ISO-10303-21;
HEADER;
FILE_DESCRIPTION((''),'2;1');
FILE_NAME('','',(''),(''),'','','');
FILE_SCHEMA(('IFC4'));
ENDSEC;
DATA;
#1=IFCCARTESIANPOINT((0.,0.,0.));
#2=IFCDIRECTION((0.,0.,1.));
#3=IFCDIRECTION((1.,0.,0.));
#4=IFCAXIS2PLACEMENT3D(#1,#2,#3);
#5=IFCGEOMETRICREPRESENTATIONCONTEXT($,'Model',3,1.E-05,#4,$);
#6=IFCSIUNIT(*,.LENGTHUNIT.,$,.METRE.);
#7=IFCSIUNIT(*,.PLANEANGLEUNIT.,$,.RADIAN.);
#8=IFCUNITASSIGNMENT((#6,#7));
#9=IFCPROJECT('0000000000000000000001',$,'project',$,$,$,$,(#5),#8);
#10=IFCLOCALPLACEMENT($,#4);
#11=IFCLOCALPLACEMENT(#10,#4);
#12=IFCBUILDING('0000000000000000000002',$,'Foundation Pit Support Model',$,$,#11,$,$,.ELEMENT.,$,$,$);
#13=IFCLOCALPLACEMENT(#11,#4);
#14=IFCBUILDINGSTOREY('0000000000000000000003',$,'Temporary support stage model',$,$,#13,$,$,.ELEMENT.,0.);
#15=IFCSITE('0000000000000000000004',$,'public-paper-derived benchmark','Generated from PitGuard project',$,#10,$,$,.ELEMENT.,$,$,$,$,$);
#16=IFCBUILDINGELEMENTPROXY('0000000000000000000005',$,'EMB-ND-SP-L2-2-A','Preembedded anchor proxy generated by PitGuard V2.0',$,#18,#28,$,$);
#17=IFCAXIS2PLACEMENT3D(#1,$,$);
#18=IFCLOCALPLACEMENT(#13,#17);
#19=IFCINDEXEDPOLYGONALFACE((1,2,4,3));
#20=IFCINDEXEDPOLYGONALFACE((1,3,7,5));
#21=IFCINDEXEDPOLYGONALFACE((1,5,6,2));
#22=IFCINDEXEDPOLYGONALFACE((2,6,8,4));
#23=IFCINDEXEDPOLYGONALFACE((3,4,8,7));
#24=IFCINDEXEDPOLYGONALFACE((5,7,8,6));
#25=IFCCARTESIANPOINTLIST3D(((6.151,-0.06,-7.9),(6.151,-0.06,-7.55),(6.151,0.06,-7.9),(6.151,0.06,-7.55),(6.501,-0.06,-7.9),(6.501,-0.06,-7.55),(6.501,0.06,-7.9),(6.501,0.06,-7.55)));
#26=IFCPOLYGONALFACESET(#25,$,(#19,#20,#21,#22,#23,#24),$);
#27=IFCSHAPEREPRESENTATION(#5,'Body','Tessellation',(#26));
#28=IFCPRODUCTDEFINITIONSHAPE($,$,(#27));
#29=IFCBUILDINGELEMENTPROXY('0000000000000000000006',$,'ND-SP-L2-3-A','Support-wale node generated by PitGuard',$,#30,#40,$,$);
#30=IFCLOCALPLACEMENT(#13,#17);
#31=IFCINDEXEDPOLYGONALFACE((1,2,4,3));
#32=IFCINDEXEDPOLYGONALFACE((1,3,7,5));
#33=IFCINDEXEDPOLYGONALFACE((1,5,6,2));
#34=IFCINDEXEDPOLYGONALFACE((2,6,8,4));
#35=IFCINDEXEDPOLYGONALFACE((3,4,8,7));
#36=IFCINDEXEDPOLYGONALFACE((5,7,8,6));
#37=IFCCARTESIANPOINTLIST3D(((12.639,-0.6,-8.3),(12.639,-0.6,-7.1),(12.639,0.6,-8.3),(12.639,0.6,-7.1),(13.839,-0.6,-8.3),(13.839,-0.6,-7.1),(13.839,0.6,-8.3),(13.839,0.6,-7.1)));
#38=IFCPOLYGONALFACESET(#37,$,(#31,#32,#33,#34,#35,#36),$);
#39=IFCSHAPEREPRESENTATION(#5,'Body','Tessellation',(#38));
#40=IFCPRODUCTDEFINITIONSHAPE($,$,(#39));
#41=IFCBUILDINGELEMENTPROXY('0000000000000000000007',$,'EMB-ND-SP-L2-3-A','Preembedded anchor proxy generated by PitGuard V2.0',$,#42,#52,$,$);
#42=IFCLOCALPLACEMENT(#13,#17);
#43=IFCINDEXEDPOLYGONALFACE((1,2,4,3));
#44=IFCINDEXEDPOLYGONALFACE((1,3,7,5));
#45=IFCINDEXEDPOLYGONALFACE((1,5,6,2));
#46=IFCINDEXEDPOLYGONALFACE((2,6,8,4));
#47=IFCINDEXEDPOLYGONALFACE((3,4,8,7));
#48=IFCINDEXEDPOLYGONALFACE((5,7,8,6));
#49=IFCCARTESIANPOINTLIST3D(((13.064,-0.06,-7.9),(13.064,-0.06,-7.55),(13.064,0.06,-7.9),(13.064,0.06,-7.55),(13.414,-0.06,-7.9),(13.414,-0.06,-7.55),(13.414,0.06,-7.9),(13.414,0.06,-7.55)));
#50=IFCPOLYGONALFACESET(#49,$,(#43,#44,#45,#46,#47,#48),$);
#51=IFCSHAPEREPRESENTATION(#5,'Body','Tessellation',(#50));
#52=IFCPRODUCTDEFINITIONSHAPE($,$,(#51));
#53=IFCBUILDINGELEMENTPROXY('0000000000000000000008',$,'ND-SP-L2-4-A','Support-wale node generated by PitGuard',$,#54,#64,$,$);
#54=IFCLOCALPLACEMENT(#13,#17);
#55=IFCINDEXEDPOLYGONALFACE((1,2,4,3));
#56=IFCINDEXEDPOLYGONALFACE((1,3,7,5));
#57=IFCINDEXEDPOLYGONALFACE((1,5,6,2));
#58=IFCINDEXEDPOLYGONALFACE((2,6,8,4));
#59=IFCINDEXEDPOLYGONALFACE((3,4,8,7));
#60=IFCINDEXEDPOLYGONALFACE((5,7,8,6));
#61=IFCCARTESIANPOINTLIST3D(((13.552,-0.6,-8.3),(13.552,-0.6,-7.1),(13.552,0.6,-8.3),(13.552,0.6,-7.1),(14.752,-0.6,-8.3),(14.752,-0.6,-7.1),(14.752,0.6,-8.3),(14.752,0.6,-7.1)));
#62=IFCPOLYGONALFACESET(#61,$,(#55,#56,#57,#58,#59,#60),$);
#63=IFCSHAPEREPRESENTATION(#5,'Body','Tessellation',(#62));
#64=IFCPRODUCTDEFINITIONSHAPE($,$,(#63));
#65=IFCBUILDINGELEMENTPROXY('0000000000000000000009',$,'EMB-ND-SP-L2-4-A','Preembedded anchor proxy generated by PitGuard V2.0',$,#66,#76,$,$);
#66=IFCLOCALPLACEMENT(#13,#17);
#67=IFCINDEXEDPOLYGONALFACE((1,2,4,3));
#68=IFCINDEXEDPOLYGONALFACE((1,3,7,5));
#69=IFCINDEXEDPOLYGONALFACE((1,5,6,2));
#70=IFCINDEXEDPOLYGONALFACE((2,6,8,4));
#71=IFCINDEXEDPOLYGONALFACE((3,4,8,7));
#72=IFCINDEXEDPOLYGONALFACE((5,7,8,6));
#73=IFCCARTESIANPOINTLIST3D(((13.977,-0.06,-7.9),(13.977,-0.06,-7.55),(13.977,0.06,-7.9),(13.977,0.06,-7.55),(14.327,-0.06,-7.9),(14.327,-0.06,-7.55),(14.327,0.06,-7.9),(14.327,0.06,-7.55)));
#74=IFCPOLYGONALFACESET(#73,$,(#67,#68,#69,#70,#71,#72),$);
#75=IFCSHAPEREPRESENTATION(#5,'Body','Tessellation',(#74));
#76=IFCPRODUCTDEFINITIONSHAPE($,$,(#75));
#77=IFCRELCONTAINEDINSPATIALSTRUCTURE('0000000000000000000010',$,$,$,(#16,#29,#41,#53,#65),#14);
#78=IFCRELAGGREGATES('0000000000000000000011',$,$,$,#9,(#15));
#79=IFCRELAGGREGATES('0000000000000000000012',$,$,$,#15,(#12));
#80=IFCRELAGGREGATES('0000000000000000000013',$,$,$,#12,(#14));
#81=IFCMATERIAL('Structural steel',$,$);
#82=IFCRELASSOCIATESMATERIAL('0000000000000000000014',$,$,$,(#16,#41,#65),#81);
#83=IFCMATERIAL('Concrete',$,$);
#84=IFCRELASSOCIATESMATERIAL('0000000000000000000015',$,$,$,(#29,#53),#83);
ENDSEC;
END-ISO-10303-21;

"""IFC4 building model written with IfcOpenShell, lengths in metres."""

from ifc_helpers import new_model, si_unit, frame, origin_with_axes, origin_2d, place, context, project, spatial, rectangle, extrude, material, element, save


model = new_model("IFC4")

# Units and contexts
model_context = context("Model", 3, precision=1e-05, world=origin_with_axes())
ifc_project = project(units=[si_unit("LENGTHUNIT", "METRE"), si_unit("PLANEANGLEUNIT", "RADIAN")], contexts=[model_context])

# Site, building, storey
site_placement = place(None, origin_with_axes())
site = spatial("IfcSite", under=ifc_project, at=site_placement, Name="public-paper-derived benchmark", Description="Generated from PitGuard project", CompositionType="ELEMENT")
building_placement = place(site_placement, origin_with_axes())
building = spatial("IfcBuilding", under=site, at=building_placement, Name="Foundation Pit Support Model", CompositionType="ELEMENT")
storey_placement = place(building_placement, origin_with_axes())
storey = spatial("IfcBuildingStorey", under=building, at=storey_placement, Name="Temporary support stage model", CompositionType="ELEMENT", Elevation=0.0)

# Shared definitions
ifc_material_1 = material(Name="Concrete")

# Shared definitions
ifc_material_2 = material(Name="Structural steel")

# Building element proxies
proxy_1_placement = place(storey_placement, frame((6.326, 0.0, -7.9), z_axis=(0.0, 0.0, 1.0), x_axis=(1.0, 0.0, 0.0)))
element("IfcBuildingElementProxy", 1, at=proxy_1_placement, inside=storey, material=ifc_material_2, Name="EMB-ND-SP-L2-2-A", Description="Preembedded anchor proxy generated by PitGuard V2.0", context=model_context, shape_type="SweptSolid", body=[
    extrude(rectangle(XDim=0.35, YDim=0.12, at=origin_2d()), origin_with_axes(), (0.0, 0.0, 1.0), 0.35),
])
proxy_2_placement = place(storey_placement, frame((13.239, 0.0, -8.3), z_axis=(0.0, 0.0, 1.0), x_axis=(1.0, 0.0, 0.0)))
element("IfcBuildingElementProxy", 2, at=proxy_2_placement, inside=storey, material=ifc_material_1, Name="ND-SP-L2-3-A", Description="Support-wale node generated by PitGuard", context=model_context, shape_type="SweptSolid", body=[
    extrude(rectangle(XDim=1.2, YDim=1.2, at=origin_2d()), origin_with_axes(), (0.0, 0.0, 1.0), 1.2),
])
proxy_3_placement = place(storey_placement, frame((13.239, 0.0, -7.9), z_axis=(0.0, 0.0, 1.0), x_axis=(1.0, 0.0, 0.0)))
element("IfcBuildingElementProxy", 3, at=proxy_3_placement, inside=storey, material=ifc_material_2, Name="EMB-ND-SP-L2-3-A", Description="Preembedded anchor proxy generated by PitGuard V2.0", context=model_context, shape_type="SweptSolid", body=[
    extrude(rectangle(XDim=0.35, YDim=0.12, at=origin_2d()), origin_with_axes(), (0.0, 0.0, 1.0), 0.35),
])
proxy_4_placement = place(storey_placement, frame((14.152, 0.0, -8.3), z_axis=(0.0, 0.0, 1.0), x_axis=(1.0, 0.0, 0.0)))
element("IfcBuildingElementProxy", 4, at=proxy_4_placement, inside=storey, material=ifc_material_1, Name="ND-SP-L2-4-A", Description="Support-wale node generated by PitGuard", context=model_context, shape_type="SweptSolid", body=[
    extrude(rectangle(XDim=1.2, YDim=1.2, at=origin_2d()), origin_with_axes(), (0.0, 0.0, 1.0), 1.2),
])
proxy_5_placement = place(storey_placement, frame((14.152, 0.0, -7.9), z_axis=(0.0, 0.0, 1.0), x_axis=(1.0, 0.0, 0.0)))
element("IfcBuildingElementProxy", 5, at=proxy_5_placement, inside=storey, material=ifc_material_2, Name="EMB-ND-SP-L2-4-A", Description="Preembedded anchor proxy generated by PitGuard V2.0", context=model_context, shape_type="SweptSolid", body=[
    extrude(rectangle(XDim=0.35, YDim=0.12, at=origin_2d()), origin_with_axes(), (0.0, 0.0, 1.0), 0.35),
])

save(model, "model.ifc")
